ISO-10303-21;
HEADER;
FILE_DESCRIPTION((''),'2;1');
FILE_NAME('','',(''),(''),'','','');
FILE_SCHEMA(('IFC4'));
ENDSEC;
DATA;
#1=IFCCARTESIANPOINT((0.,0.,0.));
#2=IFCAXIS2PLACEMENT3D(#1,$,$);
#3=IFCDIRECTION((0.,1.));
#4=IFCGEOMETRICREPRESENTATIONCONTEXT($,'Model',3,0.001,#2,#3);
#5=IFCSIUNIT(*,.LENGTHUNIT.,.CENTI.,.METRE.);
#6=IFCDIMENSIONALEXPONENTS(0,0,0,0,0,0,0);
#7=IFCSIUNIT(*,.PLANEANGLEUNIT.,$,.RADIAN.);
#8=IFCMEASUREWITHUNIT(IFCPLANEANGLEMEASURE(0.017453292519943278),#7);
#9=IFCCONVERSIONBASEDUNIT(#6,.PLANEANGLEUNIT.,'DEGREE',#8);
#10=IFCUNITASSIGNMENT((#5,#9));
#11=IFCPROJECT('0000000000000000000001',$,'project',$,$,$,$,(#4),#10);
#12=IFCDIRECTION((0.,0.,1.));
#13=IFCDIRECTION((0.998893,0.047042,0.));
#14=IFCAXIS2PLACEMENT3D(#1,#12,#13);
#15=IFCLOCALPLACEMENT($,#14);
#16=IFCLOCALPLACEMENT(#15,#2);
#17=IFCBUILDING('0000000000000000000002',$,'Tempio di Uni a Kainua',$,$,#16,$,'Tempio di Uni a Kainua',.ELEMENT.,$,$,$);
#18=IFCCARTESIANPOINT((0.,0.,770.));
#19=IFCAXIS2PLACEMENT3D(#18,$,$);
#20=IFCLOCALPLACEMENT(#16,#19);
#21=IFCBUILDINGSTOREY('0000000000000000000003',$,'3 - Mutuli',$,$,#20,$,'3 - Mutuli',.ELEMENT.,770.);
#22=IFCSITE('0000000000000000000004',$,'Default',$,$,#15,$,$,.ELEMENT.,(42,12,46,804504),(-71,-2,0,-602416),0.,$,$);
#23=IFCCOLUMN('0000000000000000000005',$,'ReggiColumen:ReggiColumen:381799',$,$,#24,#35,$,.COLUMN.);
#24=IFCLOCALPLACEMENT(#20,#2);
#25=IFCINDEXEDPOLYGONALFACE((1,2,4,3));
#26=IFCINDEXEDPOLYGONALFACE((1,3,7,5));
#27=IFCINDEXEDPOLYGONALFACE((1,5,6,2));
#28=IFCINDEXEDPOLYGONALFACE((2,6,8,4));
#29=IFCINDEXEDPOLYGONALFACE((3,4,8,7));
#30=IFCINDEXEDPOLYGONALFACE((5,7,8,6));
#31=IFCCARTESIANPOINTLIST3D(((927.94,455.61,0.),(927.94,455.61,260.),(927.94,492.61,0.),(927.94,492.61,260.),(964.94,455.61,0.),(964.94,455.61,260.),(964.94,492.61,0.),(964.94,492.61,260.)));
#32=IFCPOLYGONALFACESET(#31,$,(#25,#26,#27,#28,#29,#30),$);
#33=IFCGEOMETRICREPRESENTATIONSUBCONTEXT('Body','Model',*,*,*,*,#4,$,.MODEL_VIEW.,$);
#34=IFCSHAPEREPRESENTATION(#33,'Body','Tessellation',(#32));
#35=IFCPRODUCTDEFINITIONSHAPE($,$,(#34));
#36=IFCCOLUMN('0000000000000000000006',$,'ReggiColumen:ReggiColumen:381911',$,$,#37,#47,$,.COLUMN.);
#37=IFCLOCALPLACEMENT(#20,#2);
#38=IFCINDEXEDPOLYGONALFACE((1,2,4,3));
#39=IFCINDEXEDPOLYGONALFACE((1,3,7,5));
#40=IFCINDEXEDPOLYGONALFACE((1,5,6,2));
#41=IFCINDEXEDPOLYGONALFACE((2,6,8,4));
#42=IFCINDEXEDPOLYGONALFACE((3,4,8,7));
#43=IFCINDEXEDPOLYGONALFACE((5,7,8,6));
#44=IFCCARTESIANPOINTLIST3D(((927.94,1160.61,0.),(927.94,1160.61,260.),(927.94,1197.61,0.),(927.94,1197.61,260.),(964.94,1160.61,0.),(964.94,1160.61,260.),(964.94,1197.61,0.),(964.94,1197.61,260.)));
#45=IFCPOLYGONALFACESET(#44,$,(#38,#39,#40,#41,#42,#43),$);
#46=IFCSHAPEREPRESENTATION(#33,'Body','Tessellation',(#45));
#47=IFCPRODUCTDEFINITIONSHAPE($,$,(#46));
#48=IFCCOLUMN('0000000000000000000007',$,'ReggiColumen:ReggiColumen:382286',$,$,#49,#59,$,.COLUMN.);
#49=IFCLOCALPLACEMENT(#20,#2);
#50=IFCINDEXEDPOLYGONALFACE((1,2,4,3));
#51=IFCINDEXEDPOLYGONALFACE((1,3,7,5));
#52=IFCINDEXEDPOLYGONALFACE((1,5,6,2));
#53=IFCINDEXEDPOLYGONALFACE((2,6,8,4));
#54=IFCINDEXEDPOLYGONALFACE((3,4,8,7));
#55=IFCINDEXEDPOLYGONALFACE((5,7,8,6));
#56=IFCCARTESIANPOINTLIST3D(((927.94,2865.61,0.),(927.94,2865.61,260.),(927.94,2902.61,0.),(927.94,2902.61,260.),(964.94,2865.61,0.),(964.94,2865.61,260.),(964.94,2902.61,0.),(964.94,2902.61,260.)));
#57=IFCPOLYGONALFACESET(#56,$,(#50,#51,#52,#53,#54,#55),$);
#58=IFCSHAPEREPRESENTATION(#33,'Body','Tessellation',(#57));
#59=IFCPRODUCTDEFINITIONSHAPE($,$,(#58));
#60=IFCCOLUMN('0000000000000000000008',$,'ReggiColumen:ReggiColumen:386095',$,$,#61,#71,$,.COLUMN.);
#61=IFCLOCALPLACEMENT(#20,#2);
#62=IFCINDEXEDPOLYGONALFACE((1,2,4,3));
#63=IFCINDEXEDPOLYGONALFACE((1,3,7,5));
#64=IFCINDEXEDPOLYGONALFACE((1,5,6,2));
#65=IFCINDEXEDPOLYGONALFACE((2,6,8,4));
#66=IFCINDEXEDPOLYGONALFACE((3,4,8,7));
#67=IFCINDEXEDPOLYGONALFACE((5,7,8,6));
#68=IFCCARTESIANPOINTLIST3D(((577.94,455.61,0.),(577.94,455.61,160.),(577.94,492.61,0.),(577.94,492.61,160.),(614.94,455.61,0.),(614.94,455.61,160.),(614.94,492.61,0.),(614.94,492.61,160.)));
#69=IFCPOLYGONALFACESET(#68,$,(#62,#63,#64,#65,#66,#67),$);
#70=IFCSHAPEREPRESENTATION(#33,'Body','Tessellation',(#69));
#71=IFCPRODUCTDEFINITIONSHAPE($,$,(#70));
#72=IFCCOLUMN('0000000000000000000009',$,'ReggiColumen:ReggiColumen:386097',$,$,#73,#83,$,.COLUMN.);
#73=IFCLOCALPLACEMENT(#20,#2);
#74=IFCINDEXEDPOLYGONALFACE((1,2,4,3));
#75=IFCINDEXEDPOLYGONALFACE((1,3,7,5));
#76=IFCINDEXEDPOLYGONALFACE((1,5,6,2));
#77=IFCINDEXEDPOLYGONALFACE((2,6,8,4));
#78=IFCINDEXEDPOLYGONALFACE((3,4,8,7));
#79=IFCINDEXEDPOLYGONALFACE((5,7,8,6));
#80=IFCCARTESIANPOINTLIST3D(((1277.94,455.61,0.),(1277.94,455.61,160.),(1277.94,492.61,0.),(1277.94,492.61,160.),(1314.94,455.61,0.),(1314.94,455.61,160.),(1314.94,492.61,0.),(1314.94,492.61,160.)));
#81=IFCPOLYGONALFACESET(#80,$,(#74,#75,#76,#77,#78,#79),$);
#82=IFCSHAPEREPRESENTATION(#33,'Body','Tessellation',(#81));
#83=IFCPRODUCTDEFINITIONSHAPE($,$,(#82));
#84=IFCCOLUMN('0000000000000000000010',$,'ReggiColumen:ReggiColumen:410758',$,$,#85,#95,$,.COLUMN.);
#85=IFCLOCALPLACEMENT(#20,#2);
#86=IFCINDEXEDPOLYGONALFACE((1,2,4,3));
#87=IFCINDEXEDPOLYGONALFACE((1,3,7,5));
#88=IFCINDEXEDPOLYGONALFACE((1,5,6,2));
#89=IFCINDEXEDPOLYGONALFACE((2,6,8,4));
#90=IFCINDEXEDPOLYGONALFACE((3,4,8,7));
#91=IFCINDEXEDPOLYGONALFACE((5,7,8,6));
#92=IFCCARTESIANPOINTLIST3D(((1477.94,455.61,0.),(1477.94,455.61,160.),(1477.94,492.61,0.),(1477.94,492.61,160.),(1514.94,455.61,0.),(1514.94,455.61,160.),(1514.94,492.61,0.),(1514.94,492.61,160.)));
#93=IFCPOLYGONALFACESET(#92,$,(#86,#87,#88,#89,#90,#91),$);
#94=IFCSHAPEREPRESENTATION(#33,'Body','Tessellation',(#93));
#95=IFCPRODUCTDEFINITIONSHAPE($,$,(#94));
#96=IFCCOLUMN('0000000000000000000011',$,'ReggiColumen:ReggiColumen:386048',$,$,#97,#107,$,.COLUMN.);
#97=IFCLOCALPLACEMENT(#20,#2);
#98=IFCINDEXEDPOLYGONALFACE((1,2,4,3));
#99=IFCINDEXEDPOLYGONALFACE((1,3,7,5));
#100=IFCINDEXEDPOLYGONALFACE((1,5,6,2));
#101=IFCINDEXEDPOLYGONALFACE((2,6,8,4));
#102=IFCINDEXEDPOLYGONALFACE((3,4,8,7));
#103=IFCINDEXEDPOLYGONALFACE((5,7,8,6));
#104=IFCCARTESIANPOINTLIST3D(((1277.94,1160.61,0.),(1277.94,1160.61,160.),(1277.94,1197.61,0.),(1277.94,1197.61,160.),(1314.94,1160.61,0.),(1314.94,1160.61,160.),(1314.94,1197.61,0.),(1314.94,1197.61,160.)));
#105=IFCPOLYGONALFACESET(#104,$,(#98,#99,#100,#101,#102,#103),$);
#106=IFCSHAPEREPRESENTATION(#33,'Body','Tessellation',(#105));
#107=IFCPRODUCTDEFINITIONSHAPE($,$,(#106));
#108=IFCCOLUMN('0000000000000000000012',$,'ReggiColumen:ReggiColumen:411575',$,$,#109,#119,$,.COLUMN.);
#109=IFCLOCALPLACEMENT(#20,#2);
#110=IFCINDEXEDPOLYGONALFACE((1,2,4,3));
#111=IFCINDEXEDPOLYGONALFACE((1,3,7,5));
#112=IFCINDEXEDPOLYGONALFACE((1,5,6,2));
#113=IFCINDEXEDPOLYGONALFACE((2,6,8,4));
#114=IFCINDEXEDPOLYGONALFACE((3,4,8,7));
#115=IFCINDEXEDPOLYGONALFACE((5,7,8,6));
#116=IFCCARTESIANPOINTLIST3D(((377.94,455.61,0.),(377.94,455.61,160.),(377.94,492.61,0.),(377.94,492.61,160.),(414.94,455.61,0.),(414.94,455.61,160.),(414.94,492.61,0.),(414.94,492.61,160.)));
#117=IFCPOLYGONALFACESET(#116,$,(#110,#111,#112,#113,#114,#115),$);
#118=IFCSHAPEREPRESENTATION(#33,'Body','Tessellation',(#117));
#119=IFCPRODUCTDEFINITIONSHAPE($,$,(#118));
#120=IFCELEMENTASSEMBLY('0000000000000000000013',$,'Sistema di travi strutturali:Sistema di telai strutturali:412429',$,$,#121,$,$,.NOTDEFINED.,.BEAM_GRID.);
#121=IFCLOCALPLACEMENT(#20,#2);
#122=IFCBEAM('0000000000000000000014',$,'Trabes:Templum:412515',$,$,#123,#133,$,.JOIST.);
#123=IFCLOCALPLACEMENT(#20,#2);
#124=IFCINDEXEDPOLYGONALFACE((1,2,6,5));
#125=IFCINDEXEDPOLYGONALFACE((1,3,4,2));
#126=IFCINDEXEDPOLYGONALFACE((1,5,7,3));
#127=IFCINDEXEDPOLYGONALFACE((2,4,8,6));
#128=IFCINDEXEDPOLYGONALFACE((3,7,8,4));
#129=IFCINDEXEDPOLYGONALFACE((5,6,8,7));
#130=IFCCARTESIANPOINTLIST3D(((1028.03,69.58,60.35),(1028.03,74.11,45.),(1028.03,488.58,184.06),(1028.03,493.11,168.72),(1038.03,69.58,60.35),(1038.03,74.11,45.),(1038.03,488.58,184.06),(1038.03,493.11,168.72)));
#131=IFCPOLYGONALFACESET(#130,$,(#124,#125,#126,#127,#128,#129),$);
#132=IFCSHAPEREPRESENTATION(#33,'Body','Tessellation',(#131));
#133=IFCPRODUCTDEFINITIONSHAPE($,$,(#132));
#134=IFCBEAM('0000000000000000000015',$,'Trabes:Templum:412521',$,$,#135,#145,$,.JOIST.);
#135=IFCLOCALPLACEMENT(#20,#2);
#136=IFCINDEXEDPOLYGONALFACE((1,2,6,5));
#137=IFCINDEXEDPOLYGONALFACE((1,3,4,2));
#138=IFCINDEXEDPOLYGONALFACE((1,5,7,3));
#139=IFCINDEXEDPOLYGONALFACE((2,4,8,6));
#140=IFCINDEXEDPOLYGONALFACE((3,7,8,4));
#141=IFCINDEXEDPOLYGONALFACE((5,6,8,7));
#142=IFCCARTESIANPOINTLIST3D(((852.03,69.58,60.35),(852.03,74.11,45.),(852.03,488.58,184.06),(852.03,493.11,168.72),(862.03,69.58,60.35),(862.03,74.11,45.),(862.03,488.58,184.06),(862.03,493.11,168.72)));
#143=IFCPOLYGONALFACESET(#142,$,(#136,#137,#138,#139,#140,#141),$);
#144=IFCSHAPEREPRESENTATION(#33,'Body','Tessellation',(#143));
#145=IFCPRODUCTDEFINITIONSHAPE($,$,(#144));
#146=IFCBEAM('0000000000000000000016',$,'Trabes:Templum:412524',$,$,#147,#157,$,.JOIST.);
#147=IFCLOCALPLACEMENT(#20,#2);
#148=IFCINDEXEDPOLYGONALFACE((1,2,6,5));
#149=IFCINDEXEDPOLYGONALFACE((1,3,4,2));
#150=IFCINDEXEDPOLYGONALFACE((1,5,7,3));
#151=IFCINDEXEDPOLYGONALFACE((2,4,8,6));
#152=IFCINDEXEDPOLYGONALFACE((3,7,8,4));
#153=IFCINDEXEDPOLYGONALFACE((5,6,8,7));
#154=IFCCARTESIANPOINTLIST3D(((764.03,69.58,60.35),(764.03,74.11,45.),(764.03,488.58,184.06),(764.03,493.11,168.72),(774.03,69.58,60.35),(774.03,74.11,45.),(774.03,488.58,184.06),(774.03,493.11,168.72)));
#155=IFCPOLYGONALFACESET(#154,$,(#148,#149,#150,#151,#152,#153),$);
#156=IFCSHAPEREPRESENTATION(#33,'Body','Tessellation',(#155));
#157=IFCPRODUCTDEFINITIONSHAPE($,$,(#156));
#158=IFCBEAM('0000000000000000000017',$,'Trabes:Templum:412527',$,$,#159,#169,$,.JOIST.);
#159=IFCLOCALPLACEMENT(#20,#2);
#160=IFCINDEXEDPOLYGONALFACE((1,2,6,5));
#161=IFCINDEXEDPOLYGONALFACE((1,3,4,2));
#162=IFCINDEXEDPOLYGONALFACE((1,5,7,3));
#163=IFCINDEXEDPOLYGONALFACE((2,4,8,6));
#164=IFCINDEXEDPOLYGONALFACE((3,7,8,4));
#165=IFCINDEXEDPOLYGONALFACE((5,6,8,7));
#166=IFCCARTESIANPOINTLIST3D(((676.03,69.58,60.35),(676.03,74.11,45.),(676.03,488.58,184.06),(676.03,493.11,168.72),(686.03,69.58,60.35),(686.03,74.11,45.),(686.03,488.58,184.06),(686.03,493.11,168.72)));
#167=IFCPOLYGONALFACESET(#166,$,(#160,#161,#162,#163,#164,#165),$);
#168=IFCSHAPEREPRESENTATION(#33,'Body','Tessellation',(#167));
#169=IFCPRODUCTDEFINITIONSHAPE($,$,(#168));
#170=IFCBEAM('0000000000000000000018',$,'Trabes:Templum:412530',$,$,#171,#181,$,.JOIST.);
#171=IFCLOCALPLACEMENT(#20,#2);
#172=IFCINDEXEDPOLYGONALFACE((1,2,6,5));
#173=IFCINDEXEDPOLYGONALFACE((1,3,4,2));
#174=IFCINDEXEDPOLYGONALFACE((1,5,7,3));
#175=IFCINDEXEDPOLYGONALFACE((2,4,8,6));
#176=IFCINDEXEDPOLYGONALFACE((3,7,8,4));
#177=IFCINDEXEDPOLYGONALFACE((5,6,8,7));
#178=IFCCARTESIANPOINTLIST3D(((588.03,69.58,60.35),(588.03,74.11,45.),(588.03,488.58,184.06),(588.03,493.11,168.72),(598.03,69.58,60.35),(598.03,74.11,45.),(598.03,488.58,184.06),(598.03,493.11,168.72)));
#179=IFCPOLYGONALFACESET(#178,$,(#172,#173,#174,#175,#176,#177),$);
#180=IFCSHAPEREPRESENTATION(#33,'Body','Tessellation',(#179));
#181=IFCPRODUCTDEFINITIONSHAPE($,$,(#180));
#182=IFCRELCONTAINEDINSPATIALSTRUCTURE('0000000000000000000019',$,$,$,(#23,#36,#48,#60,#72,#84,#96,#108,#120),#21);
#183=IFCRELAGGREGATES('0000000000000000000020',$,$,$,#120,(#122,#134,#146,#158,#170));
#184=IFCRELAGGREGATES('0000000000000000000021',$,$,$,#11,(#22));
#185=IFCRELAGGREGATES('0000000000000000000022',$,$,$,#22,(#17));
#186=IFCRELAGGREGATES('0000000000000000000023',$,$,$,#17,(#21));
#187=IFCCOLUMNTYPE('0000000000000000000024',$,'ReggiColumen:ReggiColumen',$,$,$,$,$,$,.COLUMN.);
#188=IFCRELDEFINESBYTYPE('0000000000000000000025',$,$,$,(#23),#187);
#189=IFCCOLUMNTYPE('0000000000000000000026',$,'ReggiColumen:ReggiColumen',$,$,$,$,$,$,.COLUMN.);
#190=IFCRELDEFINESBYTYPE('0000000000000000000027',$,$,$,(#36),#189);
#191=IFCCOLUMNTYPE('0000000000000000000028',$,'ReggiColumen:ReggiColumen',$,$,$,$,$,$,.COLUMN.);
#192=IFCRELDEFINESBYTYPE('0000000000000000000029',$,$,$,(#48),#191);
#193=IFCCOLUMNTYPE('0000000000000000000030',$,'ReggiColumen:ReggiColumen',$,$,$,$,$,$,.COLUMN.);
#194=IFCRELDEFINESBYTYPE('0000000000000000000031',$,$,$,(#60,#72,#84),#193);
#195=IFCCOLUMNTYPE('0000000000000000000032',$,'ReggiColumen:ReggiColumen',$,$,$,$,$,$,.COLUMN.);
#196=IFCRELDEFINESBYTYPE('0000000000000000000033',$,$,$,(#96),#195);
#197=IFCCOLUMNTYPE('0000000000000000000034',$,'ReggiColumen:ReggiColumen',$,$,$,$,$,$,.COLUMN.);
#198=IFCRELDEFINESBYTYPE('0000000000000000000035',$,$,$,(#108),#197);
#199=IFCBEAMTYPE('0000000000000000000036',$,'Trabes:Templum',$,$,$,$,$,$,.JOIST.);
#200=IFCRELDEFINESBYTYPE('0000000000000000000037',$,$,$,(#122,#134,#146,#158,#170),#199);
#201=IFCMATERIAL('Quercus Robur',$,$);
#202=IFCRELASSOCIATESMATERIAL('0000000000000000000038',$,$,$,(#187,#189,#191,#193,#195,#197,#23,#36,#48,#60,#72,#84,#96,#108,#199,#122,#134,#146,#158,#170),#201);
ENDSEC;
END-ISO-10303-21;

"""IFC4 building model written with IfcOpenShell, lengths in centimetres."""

from ifc_helpers import new_model, entity, si_unit, converted_unit, direction, frame, frame_2d, origin, origin_2d_with_axis, place, context, subcontext, project, spatial, rectangle, extrude, source, transform, mapped, material, material_profile, profile_set, profile_usage, type_object, type_shapes, element, aggregate, save


model = new_model("IFC4")

# Units and contexts
model_context = context("Model", 3, precision=0.001, world=origin(), true_north=direction((0.0, 1.0)))
body_context = subcontext(model_context, "Body", "Model", "MODEL_VIEW")
ifc_project = project(units=[si_unit("LENGTHUNIT", "METRE", prefix="CENTI"), converted_unit("PLANEANGLEUNIT", "DEGREE", entity("IfcPlaneAngleMeasure", 0.017453292519943278), si_unit("PLANEANGLEUNIT", "RADIAN"), dimensions=[0, 0, 0, 0, 0, 0, 0])], contexts=[model_context])

# Site, building, storey
site_placement = place(None, frame((0.0, 0.0, 0.0), z_axis=(0.0, 0.0, 1.0), x_axis=(0.998893, 0.047042, 0.0)))
site = spatial("IfcSite", under=ifc_project, at=site_placement, Name="Default", CompositionType="ELEMENT", RefLatitude=(42, 12, 46, 804504), RefLongitude=(-71, -2, 0, -602416), RefElevation=0.0)
building_placement = place(site_placement, origin())
building = spatial("IfcBuilding", under=site, at=building_placement, Name="Tempio di Uni a Kainua", LongName="Tempio di Uni a Kainua", CompositionType="ELEMENT")
storey_placement = place(building_placement, frame((0.0, 0.0, 770.0)))
storey = spatial("IfcBuildingStorey", under=building, at=storey_placement, Name="3 - Mutuli", LongName="3 - Mutuli", CompositionType="ELEMENT", Elevation=770.0)

# Columns
ifc_material = material(Name="Quercus Robur")
ifc_material_profile_1 = material_profile(ifc_material, rectangle(XDim=37.0, YDim=37.0, at=frame_2d((0.0, 0.0), x_axis=(1.0, 0.0))), Name="ReggiColumen")
ifc_profile_set_1 = profile_set([ifc_material_profile_1], Name="ReggiColumen")
ifc_profile_usage_1 = profile_usage(ifc_profile_set_1)
column_type_1 = type_object("IfcColumnType", Name="ReggiColumen:ReggiColumen", PredefinedType="COLUMN", material=ifc_profile_set_1)
shared_shape_1 = source(origin(), body_context, "Body", "SweptSolid", [
    extrude(rectangle(XDim=37.0, YDim=37.0, at=frame_2d((0.0, 0.0), x_axis=(1.0, 0.0))), frame((946.44, 474.11, 770.0), z_axis=(0.0, 0.0, 1.0), x_axis=(-1.0, 0.0, 0.0)), (0.0, 0.0, 1.0), 260.0),
])
type_shapes(column_type_1, [shared_shape_1])
column_1_placement = place(storey_placement, frame((0.0, 0.0, -770.0)))
element("IfcColumn", 1, at=column_1_placement, inside=storey, type_object=column_type_1, material=ifc_profile_usage_1, Name="ReggiColumen:ReggiColumen:381799", PredefinedType="COLUMN", context=body_context, shape_type="MappedRepresentation", body=[
    mapped(shared_shape_1, transform((0.0, 0.0, 0.0), scale=1.0)),
])
column_type_2 = type_object("IfcColumnType", Name="ReggiColumen:ReggiColumen", PredefinedType="COLUMN", material=ifc_profile_set_1)
shared_shape_2 = source(origin(), body_context, "Body", "SweptSolid", [
    extrude(rectangle(XDim=37.0, YDim=37.0, at=frame_2d((0.0, 0.0), x_axis=(1.0, 0.0))), frame((946.44, 1179.11, 770.0), z_axis=(0.0, 0.0, 1.0), x_axis=(-1.0, 0.0, 0.0)), (0.0, 0.0, 1.0), 260.0),
])
type_shapes(column_type_2, [shared_shape_2])
column_2_placement = place(storey_placement, frame((0.0, 0.0, -770.0)))
element("IfcColumn", 2, at=column_2_placement, inside=storey, type_object=column_type_2, material=ifc_profile_usage_1, Name="ReggiColumen:ReggiColumen:381911", PredefinedType="COLUMN", context=body_context, shape_type="MappedRepresentation", body=[
    mapped(shared_shape_2, transform((0.0, 0.0, 0.0), scale=1.0)),
])
column_type_3 = type_object("IfcColumnType", Name="ReggiColumen:ReggiColumen", PredefinedType="COLUMN", material=ifc_profile_set_1)
shared_shape_3 = source(origin(), body_context, "Body", "SweptSolid", [
    extrude(rectangle(XDim=37.0, YDim=37.0, at=frame_2d((0.0, 0.0), x_axis=(1.0, 0.0))), frame((946.44, 2884.11, 770.0), z_axis=(0.0, 0.0, 1.0), x_axis=(-1.0, 0.0, 0.0)), (0.0, 0.0, 1.0), 260.0),
])
type_shapes(column_type_3, [shared_shape_3])
column_3_placement = place(storey_placement, frame((0.0, 0.0, -770.0)))
element("IfcColumn", 3, at=column_3_placement, inside=storey, type_object=column_type_3, material=ifc_profile_usage_1, Name="ReggiColumen:ReggiColumen:382286", PredefinedType="COLUMN", context=body_context, shape_type="MappedRepresentation", body=[
    mapped(shared_shape_3, transform((0.0, 0.0, 0.0), scale=1.0)),
])
column_type_4 = type_object("IfcColumnType", Name="ReggiColumen:ReggiColumen", PredefinedType="COLUMN", material=ifc_profile_set_1)
shared_shape_4 = source(origin(), body_context, "Body", "SweptSolid", [
    extrude(rectangle(XDim=37.0, YDim=37.0, at=origin_2d_with_axis()), frame((0.0, 0.0, 770.0), z_axis=(0.0, 0.0, 1.0), x_axis=(-1.0, 0.0, 0.0)), (0.0, 0.0, 1.0), 160.0),
])
type_shapes(column_type_4, [shared_shape_4])
for number, where, name in (
    (4, (596.44, 474.11, -770.0), "ReggiColumen:ReggiColumen:386095"),
    (5, (1296.44, 474.11, -770.0), "ReggiColumen:ReggiColumen:386097"),
    (6, (1496.44, 474.11, -770.0), "ReggiColumen:ReggiColumen:410758"),
):
    element("IfcColumn", number, at=place(storey_placement, frame(where)), inside=storey, type_object=column_type_4, material=ifc_profile_usage_1, Name=name, PredefinedType="COLUMN", context=body_context, shape_type="MappedRepresentation", body=[
        mapped(shared_shape_4, transform((0.0, 0.0, 0.0), scale=1.0)),
    ])
column_type_5 = type_object("IfcColumnType", Name="ReggiColumen:ReggiColumen", PredefinedType="COLUMN", material=ifc_profile_set_1)
shared_shape_5 = source(origin(), body_context, "Body", "SweptSolid", [
    extrude(rectangle(XDim=37.0, YDim=37.0, at=frame_2d((0.0, 0.0), x_axis=(1.0, 0.0))), frame((1296.44, 1179.11, 770.0), z_axis=(0.0, 0.0, 1.0), x_axis=(-1.0, 0.0, 0.0)), (0.0, 0.0, 1.0), 160.0),
])
type_shapes(column_type_5, [shared_shape_5])
column_4_placement = place(storey_placement, frame((0.0, 0.0, -770.0)))
element("IfcColumn", 7, at=column_4_placement, inside=storey, type_object=column_type_5, material=ifc_profile_usage_1, Name="ReggiColumen:ReggiColumen:386048", PredefinedType="COLUMN", context=body_context, shape_type="MappedRepresentation", body=[
    mapped(shared_shape_5, transform((0.0, 0.0, 0.0), scale=1.0)),
])
column_type_6 = type_object("IfcColumnType", Name="ReggiColumen:ReggiColumen", PredefinedType="COLUMN", material=ifc_profile_set_1)
shared_shape_6 = source(origin(), body_context, "Body", "SweptSolid", [
    extrude(rectangle(XDim=37.0, YDim=37.0, at=origin_2d_with_axis()), frame((0.0, 0.0, 770.0), z_axis=(0.0, 0.0, 1.0), x_axis=(0.0, 1.0, 0.0)), (0.0, 0.0, 1.0), 160.0),
])
type_shapes(column_type_6, [shared_shape_6])
column_5_placement = place(storey_placement, frame((396.44, 474.11, -770.0), z_axis=(0.0, 0.0, 1.0), x_axis=(-1.0, 0.0, 0.0)))
element("IfcColumn", 8, at=column_5_placement, inside=storey, type_object=column_type_6, material=ifc_profile_usage_1, Name="ReggiColumen:ReggiColumen:411575", PredefinedType="COLUMN", context=body_context, shape_type="MappedRepresentation", body=[
    mapped(shared_shape_6, transform((0.0, 0.0, 0.0), scale=1.0)),
])

# Element assembly, beams
assembly_placement = place(storey_placement, origin())
assembly = element("IfcElementAssembly", 9, at=assembly_placement, inside=storey, Name="Sistema di travi strutturali:Sistema di telai strutturali:412429", AssemblyPlace="NOTDEFINED", PredefinedType="BEAM_GRID")
ifc_material_profile_2 = material_profile(ifc_material, rectangle(XDim=2875.46, YDim=10.0, at=origin_2d_with_axis()), Name="Templum")
ifc_profile_set_2 = profile_set([ifc_material_profile_2], Name="Templum")
ifc_profile_usage_2 = profile_usage(ifc_profile_set_2, cardinal=2)
beam_type_1 = type_object("IfcBeamType", Name="Trabes:Templum", PredefinedType="JOIST", material=ifc_profile_set_2)
shared_shape_7 = source(origin(), body_context, "Body", "SweptSolid", [
    extrude(rectangle(XDim=436.88, YDim=10.0, at=origin_2d_with_axis()), frame((0.0, 0.0, -8.0)), (0.0, 0.0, 1.0), 16.0),
])
type_shapes(beam_type_1, [shared_shape_7])
beam_1_placement = place(assembly_placement, frame((1033.03, 281.34, 114.53), z_axis=(0.0, -0.283186, 0.959065), x_axis=(0.0, 0.959065, 0.283186)))
beam_1 = element("IfcBeam", 10, at=beam_1_placement, type_object=beam_type_1, material=ifc_profile_usage_2, Name="Trabes:Templum:412515", PredefinedType="JOIST", context=body_context, shape_type="MappedRepresentation", body=[
    mapped(shared_shape_7, transform((0.0, 0.0, 0.0), scale=1.0)),
])
beam_2_placement = place(assembly_placement, frame((857.03, 281.34, 114.53), z_axis=(0.0, -0.283186, 0.959065), x_axis=(0.0, 0.959065, 0.283186)))
beam_2 = element("IfcBeam", 11, at=beam_2_placement, type_object=beam_type_1, material=ifc_profile_usage_2, Name="Trabes:Templum:412521", PredefinedType="JOIST", context=body_context, shape_type="MappedRepresentation", body=[
    mapped(shared_shape_7, transform((0.0, 0.0, 0.0), scale=1.0)),
])
beam_3_placement = place(assembly_placement, frame((769.03, 281.34, 114.53), z_axis=(0.0, -0.283186, 0.959065), x_axis=(0.0, 0.959065, 0.283186)))
beam_3 = element("IfcBeam", 12, at=beam_3_placement, type_object=beam_type_1, material=ifc_profile_usage_2, Name="Trabes:Templum:412524", PredefinedType="JOIST", context=body_context, shape_type="MappedRepresentation", body=[
    mapped(shared_shape_7, transform((0.0, 0.0, 0.0), scale=1.0)),
])
beam_4_placement = place(assembly_placement, frame((681.03, 281.34, 114.53), z_axis=(0.0, -0.283186, 0.959065), x_axis=(0.0, 0.959065, 0.283186)))
beam_4 = element("IfcBeam", 13, at=beam_4_placement, type_object=beam_type_1, material=ifc_profile_usage_2, Name="Trabes:Templum:412527", PredefinedType="JOIST", context=body_context, shape_type="MappedRepresentation", body=[
    mapped(shared_shape_7, transform((0.0, 0.0, 0.0), scale=1.0)),
])
beam_5_placement = place(assembly_placement, frame((593.03, 281.34, 114.53), z_axis=(0.0, -0.283186, 0.959065), x_axis=(0.0, 0.959065, 0.283186)))
beam_5 = element("IfcBeam", 14, at=beam_5_placement, type_object=beam_type_1, material=ifc_profile_usage_2, Name="Trabes:Templum:412530", PredefinedType="JOIST", context=body_context, shape_type="MappedRepresentation", body=[
    mapped(shared_shape_7, transform((0.0, 0.0, 0.0), scale=1.0)),
])
aggregate(assembly, [beam_1, beam_2, beam_3, beam_4, beam_5])

save(model, "model.ifc")
